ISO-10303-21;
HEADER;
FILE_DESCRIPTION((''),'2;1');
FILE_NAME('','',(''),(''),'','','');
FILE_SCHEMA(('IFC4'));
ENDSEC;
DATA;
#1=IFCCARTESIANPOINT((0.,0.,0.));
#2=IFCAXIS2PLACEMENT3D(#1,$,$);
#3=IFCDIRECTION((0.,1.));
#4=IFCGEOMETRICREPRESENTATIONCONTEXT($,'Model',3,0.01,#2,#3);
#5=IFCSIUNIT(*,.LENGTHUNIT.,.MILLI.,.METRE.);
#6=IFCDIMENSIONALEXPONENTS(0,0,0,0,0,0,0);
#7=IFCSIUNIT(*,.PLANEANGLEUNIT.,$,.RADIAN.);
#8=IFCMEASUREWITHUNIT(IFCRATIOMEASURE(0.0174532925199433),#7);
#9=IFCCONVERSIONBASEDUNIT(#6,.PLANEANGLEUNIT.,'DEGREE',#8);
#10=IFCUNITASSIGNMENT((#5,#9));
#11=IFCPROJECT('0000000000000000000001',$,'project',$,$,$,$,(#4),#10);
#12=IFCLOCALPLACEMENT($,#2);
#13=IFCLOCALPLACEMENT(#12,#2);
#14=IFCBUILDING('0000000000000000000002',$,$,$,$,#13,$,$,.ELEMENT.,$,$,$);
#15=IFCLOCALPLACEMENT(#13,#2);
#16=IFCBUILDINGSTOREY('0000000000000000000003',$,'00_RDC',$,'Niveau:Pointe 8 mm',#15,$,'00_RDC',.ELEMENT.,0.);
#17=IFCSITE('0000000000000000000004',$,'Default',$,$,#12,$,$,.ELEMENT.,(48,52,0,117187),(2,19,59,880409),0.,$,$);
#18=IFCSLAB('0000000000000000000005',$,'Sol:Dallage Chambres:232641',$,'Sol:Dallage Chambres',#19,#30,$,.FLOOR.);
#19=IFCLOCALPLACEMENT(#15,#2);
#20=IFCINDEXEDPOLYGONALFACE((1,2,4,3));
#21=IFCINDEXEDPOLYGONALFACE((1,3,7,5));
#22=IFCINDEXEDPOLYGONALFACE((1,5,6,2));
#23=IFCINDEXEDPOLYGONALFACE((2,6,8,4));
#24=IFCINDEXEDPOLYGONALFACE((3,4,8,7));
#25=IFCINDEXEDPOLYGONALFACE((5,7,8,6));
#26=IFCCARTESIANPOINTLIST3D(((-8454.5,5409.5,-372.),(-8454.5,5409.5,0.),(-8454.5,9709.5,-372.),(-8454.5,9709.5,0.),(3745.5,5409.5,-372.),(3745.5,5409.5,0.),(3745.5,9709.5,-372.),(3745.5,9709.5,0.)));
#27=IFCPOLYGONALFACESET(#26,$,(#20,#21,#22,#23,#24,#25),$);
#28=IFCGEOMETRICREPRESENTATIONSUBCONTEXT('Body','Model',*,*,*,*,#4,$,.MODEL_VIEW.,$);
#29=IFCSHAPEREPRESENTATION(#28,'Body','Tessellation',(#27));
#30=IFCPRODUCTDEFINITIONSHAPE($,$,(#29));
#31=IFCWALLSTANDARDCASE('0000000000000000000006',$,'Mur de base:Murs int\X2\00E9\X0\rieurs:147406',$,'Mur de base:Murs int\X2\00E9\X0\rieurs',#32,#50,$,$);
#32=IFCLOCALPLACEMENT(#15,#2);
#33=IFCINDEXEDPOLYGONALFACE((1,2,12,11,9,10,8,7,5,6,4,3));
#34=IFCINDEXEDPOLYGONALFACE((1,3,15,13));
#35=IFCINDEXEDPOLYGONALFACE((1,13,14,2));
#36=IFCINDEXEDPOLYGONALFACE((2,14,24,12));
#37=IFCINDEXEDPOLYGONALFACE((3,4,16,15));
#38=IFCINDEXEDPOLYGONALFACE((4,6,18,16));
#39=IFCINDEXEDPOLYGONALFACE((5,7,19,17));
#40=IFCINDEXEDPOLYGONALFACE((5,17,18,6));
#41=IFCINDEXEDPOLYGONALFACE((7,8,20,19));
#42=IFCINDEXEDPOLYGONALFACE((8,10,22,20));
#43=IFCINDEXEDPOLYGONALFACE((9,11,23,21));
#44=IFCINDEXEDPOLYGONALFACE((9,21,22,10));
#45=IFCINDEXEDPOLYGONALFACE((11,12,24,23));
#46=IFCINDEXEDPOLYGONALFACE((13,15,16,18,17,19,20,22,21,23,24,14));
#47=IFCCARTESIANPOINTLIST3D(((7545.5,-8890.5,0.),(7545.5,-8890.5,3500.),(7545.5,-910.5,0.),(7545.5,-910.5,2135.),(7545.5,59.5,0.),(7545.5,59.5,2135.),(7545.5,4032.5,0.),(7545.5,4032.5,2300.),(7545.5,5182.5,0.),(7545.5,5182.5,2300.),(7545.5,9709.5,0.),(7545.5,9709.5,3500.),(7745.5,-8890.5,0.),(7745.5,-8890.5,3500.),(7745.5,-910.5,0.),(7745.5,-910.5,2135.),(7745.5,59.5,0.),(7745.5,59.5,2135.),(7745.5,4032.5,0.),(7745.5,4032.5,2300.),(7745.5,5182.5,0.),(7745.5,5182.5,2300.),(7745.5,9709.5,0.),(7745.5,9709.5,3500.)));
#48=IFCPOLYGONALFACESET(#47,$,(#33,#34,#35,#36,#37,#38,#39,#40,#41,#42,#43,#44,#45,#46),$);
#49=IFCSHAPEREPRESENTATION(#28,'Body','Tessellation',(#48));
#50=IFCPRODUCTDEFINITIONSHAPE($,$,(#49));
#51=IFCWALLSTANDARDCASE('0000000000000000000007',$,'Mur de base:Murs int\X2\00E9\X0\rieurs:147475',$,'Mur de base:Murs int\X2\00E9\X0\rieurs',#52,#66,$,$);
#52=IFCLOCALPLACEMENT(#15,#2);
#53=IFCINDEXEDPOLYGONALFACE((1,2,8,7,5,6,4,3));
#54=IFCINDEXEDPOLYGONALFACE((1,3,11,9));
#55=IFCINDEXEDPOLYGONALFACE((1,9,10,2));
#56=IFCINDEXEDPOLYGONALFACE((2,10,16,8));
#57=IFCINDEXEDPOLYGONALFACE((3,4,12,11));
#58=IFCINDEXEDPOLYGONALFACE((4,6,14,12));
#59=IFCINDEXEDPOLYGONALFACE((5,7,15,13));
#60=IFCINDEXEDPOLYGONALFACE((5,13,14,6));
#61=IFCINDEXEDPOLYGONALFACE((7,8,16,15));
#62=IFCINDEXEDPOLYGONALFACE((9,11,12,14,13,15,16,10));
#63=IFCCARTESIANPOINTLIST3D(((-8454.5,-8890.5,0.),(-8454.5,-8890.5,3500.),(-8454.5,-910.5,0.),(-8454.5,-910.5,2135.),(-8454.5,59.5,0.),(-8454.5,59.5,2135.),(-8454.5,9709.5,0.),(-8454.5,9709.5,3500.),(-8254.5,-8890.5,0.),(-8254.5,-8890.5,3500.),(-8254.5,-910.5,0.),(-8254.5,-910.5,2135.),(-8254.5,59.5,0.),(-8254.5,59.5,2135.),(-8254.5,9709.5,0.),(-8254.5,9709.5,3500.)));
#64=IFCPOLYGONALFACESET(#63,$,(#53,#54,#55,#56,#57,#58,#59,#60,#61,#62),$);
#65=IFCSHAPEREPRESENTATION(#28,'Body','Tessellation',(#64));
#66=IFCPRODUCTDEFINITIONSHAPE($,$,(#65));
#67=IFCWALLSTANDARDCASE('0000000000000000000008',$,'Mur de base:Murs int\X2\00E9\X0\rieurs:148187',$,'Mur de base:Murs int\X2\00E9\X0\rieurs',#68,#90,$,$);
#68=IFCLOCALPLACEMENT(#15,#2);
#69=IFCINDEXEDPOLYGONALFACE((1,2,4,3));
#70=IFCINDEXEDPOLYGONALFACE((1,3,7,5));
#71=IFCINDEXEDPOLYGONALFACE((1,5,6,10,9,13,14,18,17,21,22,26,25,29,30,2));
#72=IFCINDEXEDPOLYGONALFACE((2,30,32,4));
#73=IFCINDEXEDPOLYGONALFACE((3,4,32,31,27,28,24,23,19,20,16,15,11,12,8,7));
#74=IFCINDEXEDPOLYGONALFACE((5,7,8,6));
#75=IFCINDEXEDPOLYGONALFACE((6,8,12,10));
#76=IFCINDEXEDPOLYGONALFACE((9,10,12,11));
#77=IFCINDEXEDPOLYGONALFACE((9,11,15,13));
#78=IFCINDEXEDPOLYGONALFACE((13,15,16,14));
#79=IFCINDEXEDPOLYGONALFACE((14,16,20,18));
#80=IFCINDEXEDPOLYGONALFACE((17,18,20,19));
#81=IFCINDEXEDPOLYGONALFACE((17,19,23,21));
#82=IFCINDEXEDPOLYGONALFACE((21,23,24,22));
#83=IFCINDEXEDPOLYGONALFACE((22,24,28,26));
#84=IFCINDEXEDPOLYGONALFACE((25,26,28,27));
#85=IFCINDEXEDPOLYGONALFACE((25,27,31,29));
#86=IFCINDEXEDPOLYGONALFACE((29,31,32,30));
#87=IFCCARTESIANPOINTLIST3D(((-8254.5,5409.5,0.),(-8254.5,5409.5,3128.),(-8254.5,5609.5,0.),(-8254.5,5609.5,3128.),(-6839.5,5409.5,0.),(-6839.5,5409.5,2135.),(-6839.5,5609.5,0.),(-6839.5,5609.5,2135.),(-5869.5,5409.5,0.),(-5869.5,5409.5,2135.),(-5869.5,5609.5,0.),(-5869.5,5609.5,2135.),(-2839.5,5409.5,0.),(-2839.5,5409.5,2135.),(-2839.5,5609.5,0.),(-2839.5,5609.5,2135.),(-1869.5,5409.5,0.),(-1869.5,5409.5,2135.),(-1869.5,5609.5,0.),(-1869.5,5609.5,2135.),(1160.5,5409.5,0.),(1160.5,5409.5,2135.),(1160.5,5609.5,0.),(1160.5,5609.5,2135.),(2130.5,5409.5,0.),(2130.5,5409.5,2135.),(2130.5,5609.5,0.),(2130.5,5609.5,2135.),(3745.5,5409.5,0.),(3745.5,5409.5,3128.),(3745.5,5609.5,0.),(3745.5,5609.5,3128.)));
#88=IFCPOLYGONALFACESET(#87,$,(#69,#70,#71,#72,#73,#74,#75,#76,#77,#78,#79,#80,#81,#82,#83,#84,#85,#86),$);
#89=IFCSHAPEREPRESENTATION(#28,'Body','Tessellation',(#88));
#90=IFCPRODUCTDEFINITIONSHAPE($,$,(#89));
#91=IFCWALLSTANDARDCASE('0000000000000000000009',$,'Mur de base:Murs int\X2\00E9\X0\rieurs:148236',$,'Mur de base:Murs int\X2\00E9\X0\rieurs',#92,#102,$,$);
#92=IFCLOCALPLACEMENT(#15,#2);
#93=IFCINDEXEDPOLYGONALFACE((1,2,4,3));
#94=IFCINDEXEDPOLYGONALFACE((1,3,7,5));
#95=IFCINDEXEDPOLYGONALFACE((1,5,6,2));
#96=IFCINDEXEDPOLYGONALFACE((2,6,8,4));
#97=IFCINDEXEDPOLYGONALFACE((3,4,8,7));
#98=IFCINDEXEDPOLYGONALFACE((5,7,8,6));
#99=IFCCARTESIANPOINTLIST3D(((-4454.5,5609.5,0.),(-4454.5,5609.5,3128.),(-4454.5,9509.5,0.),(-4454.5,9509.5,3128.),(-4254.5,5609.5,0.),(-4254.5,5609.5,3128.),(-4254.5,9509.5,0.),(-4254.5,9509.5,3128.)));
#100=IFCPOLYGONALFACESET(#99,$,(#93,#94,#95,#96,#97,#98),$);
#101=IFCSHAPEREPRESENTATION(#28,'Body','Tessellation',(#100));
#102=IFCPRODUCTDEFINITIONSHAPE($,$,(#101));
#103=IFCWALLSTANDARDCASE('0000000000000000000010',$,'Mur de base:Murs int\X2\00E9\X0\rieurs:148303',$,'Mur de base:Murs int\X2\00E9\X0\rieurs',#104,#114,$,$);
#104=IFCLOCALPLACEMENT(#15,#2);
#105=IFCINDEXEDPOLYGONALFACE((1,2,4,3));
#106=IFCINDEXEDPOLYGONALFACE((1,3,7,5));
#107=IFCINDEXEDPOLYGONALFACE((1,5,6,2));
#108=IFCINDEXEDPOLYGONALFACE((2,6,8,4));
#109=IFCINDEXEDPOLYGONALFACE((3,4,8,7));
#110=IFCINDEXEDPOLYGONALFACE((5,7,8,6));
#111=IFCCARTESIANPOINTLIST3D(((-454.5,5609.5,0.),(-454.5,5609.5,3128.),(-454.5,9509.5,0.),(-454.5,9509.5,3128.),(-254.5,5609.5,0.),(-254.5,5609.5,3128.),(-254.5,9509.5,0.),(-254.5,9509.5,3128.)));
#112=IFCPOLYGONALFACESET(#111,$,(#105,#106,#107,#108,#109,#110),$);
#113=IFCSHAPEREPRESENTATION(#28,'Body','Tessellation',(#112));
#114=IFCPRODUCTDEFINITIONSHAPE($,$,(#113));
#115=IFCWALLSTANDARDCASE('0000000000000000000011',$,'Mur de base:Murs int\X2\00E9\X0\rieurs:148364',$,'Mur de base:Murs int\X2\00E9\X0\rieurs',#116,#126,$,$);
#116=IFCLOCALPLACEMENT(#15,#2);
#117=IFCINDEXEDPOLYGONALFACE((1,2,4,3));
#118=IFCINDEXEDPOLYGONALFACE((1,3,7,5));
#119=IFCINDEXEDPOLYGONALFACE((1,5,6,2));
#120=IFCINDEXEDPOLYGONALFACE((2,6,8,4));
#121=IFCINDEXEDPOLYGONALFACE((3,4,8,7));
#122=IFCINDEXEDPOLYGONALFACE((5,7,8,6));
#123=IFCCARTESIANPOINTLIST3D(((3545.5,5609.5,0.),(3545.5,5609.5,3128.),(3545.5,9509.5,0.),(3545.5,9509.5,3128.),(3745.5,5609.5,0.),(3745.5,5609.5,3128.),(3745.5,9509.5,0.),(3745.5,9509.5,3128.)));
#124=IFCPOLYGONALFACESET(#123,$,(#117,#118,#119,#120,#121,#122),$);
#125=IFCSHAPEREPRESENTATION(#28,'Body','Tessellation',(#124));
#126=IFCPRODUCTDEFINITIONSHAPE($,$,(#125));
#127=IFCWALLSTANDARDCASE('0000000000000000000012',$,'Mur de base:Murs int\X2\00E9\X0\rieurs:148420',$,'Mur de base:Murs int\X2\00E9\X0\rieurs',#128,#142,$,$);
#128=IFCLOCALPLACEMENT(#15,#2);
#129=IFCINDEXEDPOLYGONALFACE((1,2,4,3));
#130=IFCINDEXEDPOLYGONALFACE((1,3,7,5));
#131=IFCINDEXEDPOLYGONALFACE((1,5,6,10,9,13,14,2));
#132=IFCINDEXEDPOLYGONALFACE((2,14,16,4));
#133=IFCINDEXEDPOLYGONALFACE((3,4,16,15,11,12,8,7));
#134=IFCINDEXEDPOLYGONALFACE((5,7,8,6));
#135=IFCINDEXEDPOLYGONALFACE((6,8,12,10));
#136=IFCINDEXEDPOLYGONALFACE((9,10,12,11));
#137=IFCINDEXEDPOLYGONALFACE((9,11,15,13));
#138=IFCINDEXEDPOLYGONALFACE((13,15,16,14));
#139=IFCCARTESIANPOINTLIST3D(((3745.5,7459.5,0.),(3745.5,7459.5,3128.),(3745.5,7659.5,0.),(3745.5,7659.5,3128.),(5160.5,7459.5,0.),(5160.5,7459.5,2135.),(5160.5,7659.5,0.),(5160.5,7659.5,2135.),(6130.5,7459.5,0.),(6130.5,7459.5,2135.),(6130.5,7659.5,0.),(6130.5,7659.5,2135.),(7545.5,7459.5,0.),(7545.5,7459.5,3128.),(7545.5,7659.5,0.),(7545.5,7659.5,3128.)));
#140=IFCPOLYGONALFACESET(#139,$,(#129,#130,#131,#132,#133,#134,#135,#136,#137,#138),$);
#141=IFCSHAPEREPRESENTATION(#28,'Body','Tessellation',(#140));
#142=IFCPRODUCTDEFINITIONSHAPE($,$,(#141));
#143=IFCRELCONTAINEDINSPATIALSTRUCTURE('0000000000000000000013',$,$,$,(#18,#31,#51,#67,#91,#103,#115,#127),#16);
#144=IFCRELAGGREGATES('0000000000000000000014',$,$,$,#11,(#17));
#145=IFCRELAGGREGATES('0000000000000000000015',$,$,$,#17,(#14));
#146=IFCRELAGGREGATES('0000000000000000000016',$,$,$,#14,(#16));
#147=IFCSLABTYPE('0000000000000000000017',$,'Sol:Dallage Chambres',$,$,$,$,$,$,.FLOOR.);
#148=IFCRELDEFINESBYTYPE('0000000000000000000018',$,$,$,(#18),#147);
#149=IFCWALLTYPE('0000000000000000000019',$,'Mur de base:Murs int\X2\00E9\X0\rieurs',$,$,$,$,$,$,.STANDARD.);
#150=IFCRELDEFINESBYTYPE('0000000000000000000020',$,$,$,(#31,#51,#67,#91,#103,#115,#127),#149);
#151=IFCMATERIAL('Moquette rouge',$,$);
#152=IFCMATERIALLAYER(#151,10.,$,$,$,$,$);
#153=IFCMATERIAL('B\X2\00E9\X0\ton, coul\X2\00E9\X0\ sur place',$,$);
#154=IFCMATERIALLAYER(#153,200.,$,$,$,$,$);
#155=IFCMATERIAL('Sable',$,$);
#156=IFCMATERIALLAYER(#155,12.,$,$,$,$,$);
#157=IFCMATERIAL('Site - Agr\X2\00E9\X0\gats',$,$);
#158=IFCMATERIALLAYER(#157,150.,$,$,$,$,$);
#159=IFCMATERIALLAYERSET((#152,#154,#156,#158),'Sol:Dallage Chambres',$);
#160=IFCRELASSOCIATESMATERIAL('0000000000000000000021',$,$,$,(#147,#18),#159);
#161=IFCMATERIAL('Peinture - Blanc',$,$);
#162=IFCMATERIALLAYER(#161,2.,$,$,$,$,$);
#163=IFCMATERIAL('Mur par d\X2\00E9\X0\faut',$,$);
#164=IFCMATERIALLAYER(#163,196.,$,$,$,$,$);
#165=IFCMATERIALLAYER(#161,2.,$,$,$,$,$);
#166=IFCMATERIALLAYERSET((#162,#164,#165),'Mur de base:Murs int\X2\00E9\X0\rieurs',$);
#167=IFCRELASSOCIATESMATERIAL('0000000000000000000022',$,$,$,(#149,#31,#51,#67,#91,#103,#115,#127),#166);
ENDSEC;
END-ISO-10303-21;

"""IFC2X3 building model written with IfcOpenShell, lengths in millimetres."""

from ifc_helpers import new_model, entity, si_unit, converted_unit, direction, frame, frame_2d, origin, origin_2d_with_axis, place, context, subcontext, project, spatial, polyline, rectangle, extrude, clip, bounded_halfspace, material, layer, layer_set, layer_usage, type_object, element, save


model = new_model("IFC2X3")

# Units and contexts
model_context = context("Model", 3, precision=0.01, world=origin(), true_north=direction((0.0, 1.0)))
body_context = subcontext(model_context, "Body", "Model", "MODEL_VIEW")
ifc_project = project(units=[si_unit("LENGTHUNIT", "METRE", prefix="MILLI"), converted_unit("PLANEANGLEUNIT", "DEGREE", entity("IfcRatioMeasure", 0.0174532925199433), si_unit("PLANEANGLEUNIT", "RADIAN"), dimensions=[0, 0, 0, 0, 0, 0, 0])], contexts=[model_context])

# Site, building, storey
site_placement = place(None, origin())
site = spatial("IfcSite", under=ifc_project, at=site_placement, Name="Default", CompositionType="ELEMENT", RefLatitude=(48, 52, 0, 117187), RefLongitude=(2, 19, 59, 880409), RefElevation=0.0)
building_placement = place(site_placement, origin())
building = spatial("IfcBuilding", under=site, at=building_placement, CompositionType="ELEMENT")
storey_placement = place(building_placement, origin())
storey = spatial("IfcBuildingStorey", under=building, at=storey_placement, Name="00_RDC", ObjectType="Niveau:Pointe 8 mm", LongName="00_RDC", CompositionType="ELEMENT", Elevation=0.0)

# Shared definitions
ifc_material_1 = material(Name="Béton, coulé sur place")
ifc_material_2 = material(Name="Sable")
ifc_material_3 = material(Name="Site - Agrégats")

# Slab
ifc_material_4 = material(Name="Moquette rouge")
ifc_layer_1 = layer(ifc_material_4, 10.0)
ifc_layer_2 = layer(ifc_material_1, 200.0)
ifc_layer_3 = layer(ifc_material_2, 12.0)
ifc_layer_4 = layer(ifc_material_3, 150.0)
ifc_layer_set_1 = layer_set([ifc_layer_1, ifc_layer_2, ifc_layer_3, ifc_layer_4], Name="Sol:Dallage Chambres")
ifc_layer_usage_1 = layer_usage(ifc_layer_set_1, "AXIS3", "POSITIVE", 0.0)
slab_type_1 = type_object("IfcSlabType", Name="Sol:Dallage Chambres", PredefinedType="FLOOR", material=ifc_layer_set_1)
slab_1_placement = place(storey_placement, origin())
element("IfcSlab", 1, at=slab_1_placement, inside=storey, type_object=slab_type_1, material=ifc_layer_usage_1, Name="Sol:Dallage Chambres:232641", ObjectType="Sol:Dallage Chambres", PredefinedType="FLOOR", context=body_context, shape_type="SweptSolid", body=[
    extrude(rectangle(XDim=4300.0, YDim=12200.0, at=frame_2d((0.0, 0.0), x_axis=(1.0, 0.0))), frame((-2354.5, 7559.5, 0.0), z_axis=(0.0, 0.0, -1.0), x_axis=(0.0, 1.0, 0.0)), (0.0, 0.0, 1.0), 372.0),
])

# Wall, openings
ifc_material_5 = material(Name="Peinture - Blanc")
ifc_layer_5 = layer(ifc_material_5, 2.0)
ifc_material_6 = material(Name="Mur par défaut")
ifc_layer_6 = layer(ifc_material_6, 196.0)
ifc_layer_7 = layer(ifc_material_5, 2.0)
ifc_layer_set_2 = layer_set([ifc_layer_5, ifc_layer_6, ifc_layer_7], Name="Mur de base:Murs intérieurs")
ifc_layer_usage_2 = layer_usage(ifc_layer_set_2, "AXIS2", "NEGATIVE", 100.0)
wall_type_1 = type_object("IfcWallType", Name="Mur de base:Murs intérieurs", PredefinedType="STANDARD", material=ifc_layer_set_2)
wall_1_placement = place(storey_placement, frame((7645.5, -8890.5, 0.0), z_axis=(0.0, 0.0, 1.0), x_axis=(0.0, 1.0, 0.0)))
wall_1 = element("IfcWallStandardCase", 2, at=wall_1_placement, inside=storey, type_object=wall_type_1, material=ifc_layer_usage_2, Name="Mur de base:Murs intérieurs:147406", ObjectType="Mur de base:Murs intérieurs", context=body_context, shape_type="SweptSolid", body=[
    extrude(rectangle(XDim=18600.0, YDim=200.0, at=frame_2d((9300.0, 0.0), x_axis=(-1.0, 0.0))), origin(), (0.0, 0.0, 1.0), 3500.0),
])
opening_1_placement = place(wall_1_placement, origin())
element("IfcOpeningElement", 3, at=opening_1_placement, cuts=wall_1, ObjectType="Opening", context=body_context, shape_type="SweptSolid", body=[
    extrude(rectangle(XDim=2300.0, YDim=1150.0, at=origin_2d_with_axis()), frame((13498.0, -100.0, 1150.0), z_axis=(0.0, 1.0, 0.0), x_axis=(0.0, 0.0, -1.0)), (0.0, 0.0, 1.0), 200.0),
])
opening_2_placement = place(wall_1_placement, frame((8950.0, 100.0, 0.0)))
element("IfcOpeningElement", 4, at=opening_2_placement, cuts=wall_1, ObjectType="Opening", context=body_context, shape_type="SweptSolid", body=[
    extrude(rectangle(XDim=2135.0, YDim=970.0, at=frame_2d((1067.5, 485.0), x_axis=(1.0, 0.0))), frame((0.0, 0.0, 0.0), z_axis=(0.0, -1.0, 0.0), x_axis=(0.0, 0.0, 1.0)), (0.0, 0.0, 1.0), 200.0),
])

# Wall, opening
ifc_layer_usage_3 = layer_usage(ifc_layer_set_2, "AXIS2", "NEGATIVE", 100.0)
wall_2_placement = place(storey_placement, frame((-8354.5, -8890.5, 0.0), z_axis=(0.0, 0.0, 1.0), x_axis=(0.0, 1.0, 0.0)))
wall_2 = element("IfcWallStandardCase", 5, at=wall_2_placement, inside=storey, type_object=wall_type_1, material=ifc_layer_usage_3, Name="Mur de base:Murs intérieurs:147475", ObjectType="Mur de base:Murs intérieurs", context=body_context, shape_type="SweptSolid", body=[
    extrude(rectangle(XDim=18600.0, YDim=200.0, at=frame_2d((9300.0, 0.0), x_axis=(-1.0, 0.0))), origin(), (0.0, 0.0, 1.0), 3500.0),
])
opening_3_placement = place(wall_2_placement, frame((7980.0, -100.0, 0.0)))
element("IfcOpeningElement", 6, at=opening_3_placement, cuts=wall_2, ObjectType="Opening", context=body_context, shape_type="SweptSolid", body=[
    extrude(rectangle(XDim=2135.0, YDim=970.0, at=frame_2d((1067.5, 485.0), x_axis=(1.0, 0.0))), frame((0.0, 0.0, 0.0), z_axis=(0.0, 1.0, 0.0), x_axis=(0.0, 0.0, 1.0)), (0.0, 0.0, 1.0), 200.0),
])

# Wall, openings
ifc_layer_usage_4 = layer_usage(ifc_layer_set_2, "AXIS2", "NEGATIVE", 100.0)
wall_3_placement = place(storey_placement, frame((-8254.5, 5509.5, 0.0)))
wall_3 = element("IfcWallStandardCase", 7, at=wall_3_placement, inside=storey, type_object=wall_type_1, material=ifc_layer_usage_4, Name="Mur de base:Murs intérieurs:148187", ObjectType="Mur de base:Murs intérieurs", context=body_context, shape_type="Clipping", body=[
    clip(extrude(rectangle(XDim=12000.0, YDim=200.0, at=frame_2d((6000.0, 0.0), x_axis=(-1.0, 0.0))), origin(), (0.0, 0.0, 1.0), 3128.0), bounded_halfspace(frame((0.0, -100.0, 3128.0), z_axis=(0.0, 0.0, -1.0), x_axis=(-1.0, 0.0, 0.0)), True, frame((0.0, -100.0, 3128.0)), polyline([(0.0, 0.0), (12000.0, 0.0), (12000.0, 200.0), (11800.0, 200.0), (8000.0, 200.0), (7800.0, 200.0), (4000.0, 200.0), (3800.0, 200.0), (0.0, 200.0), (0.0, 0.0)]))),
])
opening_4_placement = place(wall_3_placement, frame((1415.0, -100.0, 0.0)))
element("IfcOpeningElement", 8, at=opening_4_placement, cuts=wall_3, ObjectType="Opening", context=body_context, shape_type="SweptSolid", body=[
    extrude(rectangle(XDim=2135.0, YDim=970.0, at=frame_2d((1067.5, 485.0), x_axis=(1.0, 0.0))), frame((0.0, 0.0, 0.0), z_axis=(0.0, 1.0, 0.0), x_axis=(0.0, 0.0, 1.0)), (0.0, 0.0, 1.0), 200.0),
])
opening_5_placement = place(wall_3_placement, frame((5415.0, -100.0, 0.0)))
element("IfcOpeningElement", 9, at=opening_5_placement, cuts=wall_3, ObjectType="Opening", context=body_context, shape_type="SweptSolid", body=[
    extrude(rectangle(XDim=2135.0, YDim=970.0, at=frame_2d((1067.5, 485.0), x_axis=(1.0, 0.0))), frame((0.0, 0.0, 0.0), z_axis=(0.0, 1.0, 0.0), x_axis=(0.0, 0.0, 1.0)), (0.0, 0.0, 1.0), 200.0),
])
opening_6_placement = place(wall_3_placement, frame((9415.0, -100.0, 0.0)))
element("IfcOpeningElement", 10, at=opening_6_placement, cuts=wall_3, ObjectType="Opening", context=body_context, shape_type="SweptSolid", body=[
    extrude(rectangle(XDim=2135.0, YDim=970.0, at=frame_2d((1067.5, 485.0), x_axis=(1.0, 0.0))), frame((0.0, 0.0, 0.0), z_axis=(0.0, 1.0, 0.0), x_axis=(0.0, 0.0, 1.0)), (0.0, 0.0, 1.0), 200.0),
])

# Walls
ifc_layer_usage_5 = layer_usage(ifc_layer_set_2, "AXIS2", "NEGATIVE", 100.0)
wall_4_placement = place(storey_placement, frame((-4354.5, 5609.5, 0.0), z_axis=(0.0, 0.0, 1.0), x_axis=(0.0, 1.0, 0.0)))
element("IfcWallStandardCase", 11, at=wall_4_placement, inside=storey, type_object=wall_type_1, material=ifc_layer_usage_5, Name="Mur de base:Murs intérieurs:148236", ObjectType="Mur de base:Murs intérieurs", context=body_context, shape_type="Clipping", body=[
    clip(extrude(rectangle(XDim=3900.0, YDim=200.0, at=frame_2d((1950.0, 0.0), x_axis=(-1.0, 0.0))), origin(), (0.0, 0.0, 1.0), 3128.0), bounded_halfspace(frame((0.0, -100.0, 3128.0), z_axis=(0.0, 0.0, -1.0), x_axis=(0.0, 1.0, 0.0)), True, frame((0.0, -100.0, 3128.0)), polyline([(0.0, 0.0), (3900.0, 0.0), (3900.0, 200.0), (0.0, 200.0), (0.0, 0.0)]))),
])
ifc_layer_usage_6 = layer_usage(ifc_layer_set_2, "AXIS2", "NEGATIVE", 100.0)
wall_5_placement = place(storey_placement, frame((-354.5, 5609.5, 0.0), z_axis=(0.0, 0.0, 1.0), x_axis=(0.0, 1.0, 0.0)))
element("IfcWallStandardCase", 12, at=wall_5_placement, inside=storey, type_object=wall_type_1, material=ifc_layer_usage_6, Name="Mur de base:Murs intérieurs:148303", ObjectType="Mur de base:Murs intérieurs", context=body_context, shape_type="Clipping", body=[
    clip(extrude(rectangle(XDim=3900.0, YDim=200.0, at=frame_2d((1950.0, 0.0), x_axis=(-1.0, 0.0))), origin(), (0.0, 0.0, 1.0), 3128.0), bounded_halfspace(frame((0.0, -100.0, 3128.0), z_axis=(0.0, 0.0, -1.0), x_axis=(0.0, 1.0, 0.0)), True, frame((0.0, -100.0, 3128.0)), polyline([(0.0, 0.0), (3900.0, 0.0), (3900.0, 200.0), (0.0, 200.0), (0.0, 0.0)]))),
])
ifc_layer_usage_7 = layer_usage(ifc_layer_set_2, "AXIS2", "NEGATIVE", 100.0)
wall_6_placement = place(storey_placement, frame((3645.5, 5609.5, 0.0), z_axis=(0.0, 0.0, 1.0), x_axis=(0.0, 1.0, 0.0)))
element("IfcWallStandardCase", 13, at=wall_6_placement, inside=storey, type_object=wall_type_1, material=ifc_layer_usage_7, Name="Mur de base:Murs intérieurs:148364", ObjectType="Mur de base:Murs intérieurs", context=body_context, shape_type="Clipping", body=[
    clip(extrude(rectangle(XDim=3900.0, YDim=200.0, at=frame_2d((1950.0, 0.0), x_axis=(-1.0, 0.0))), origin(), (0.0, 0.0, 1.0), 3128.0), bounded_halfspace(frame((0.0, -100.0, 3128.0), z_axis=(0.0, 0.0, -1.0), x_axis=(0.0, 1.0, 0.0)), True, frame((0.0, -100.0, 3128.0)), polyline([(0.0, 0.0), (1850.0, 0.0), (2050.0, 0.0), (3900.0, 0.0), (3900.0, 200.0), (0.0, 200.0), (0.0, 0.0)]))),
])

# Wall, opening
ifc_layer_usage_8 = layer_usage(ifc_layer_set_2, "AXIS2", "NEGATIVE", 100.0)
wall_7_placement = place(storey_placement, frame((3745.5, 7559.5, 0.0)))
wall_7 = element("IfcWallStandardCase", 14, at=wall_7_placement, inside=storey, type_object=wall_type_1, material=ifc_layer_usage_8, Name="Mur de base:Murs intérieurs:148420", ObjectType="Mur de base:Murs intérieurs", context=body_context, shape_type="Clipping", body=[
    clip(extrude(rectangle(XDim=3800.0, YDim=200.0, at=frame_2d((1900.0, 0.0), x_axis=(-1.0, 0.0))), origin(), (0.0, 0.0, 1.0), 3128.0), bounded_halfspace(frame((0.0, -100.0, 3128.0), z_axis=(0.0, 0.0, -1.0), x_axis=(0.0, 1.0, 0.0)), True, frame((0.0, -100.0, 3128.0)), polyline([(0.0, 0.0), (3800.0, 0.0), (3800.0, 200.0), (0.0, 200.0), (0.0, 0.0)]))),
])
opening_7_placement = place(wall_7_placement, frame((2385.0, 100.0, 0.0)))
element("IfcOpeningElement", 15, at=opening_7_placement, cuts=wall_7, ObjectType="Opening", context=body_context, shape_type="SweptSolid", body=[
    extrude(rectangle(XDim=2135.0, YDim=970.0, at=frame_2d((1067.5, 485.0), x_axis=(1.0, 0.0))), frame((0.0, 0.0, 0.0), z_axis=(0.0, -1.0, 0.0), x_axis=(0.0, 0.0, 1.0)), (0.0, 0.0, 1.0), 200.0),
])

save(model, "model.ifc")
